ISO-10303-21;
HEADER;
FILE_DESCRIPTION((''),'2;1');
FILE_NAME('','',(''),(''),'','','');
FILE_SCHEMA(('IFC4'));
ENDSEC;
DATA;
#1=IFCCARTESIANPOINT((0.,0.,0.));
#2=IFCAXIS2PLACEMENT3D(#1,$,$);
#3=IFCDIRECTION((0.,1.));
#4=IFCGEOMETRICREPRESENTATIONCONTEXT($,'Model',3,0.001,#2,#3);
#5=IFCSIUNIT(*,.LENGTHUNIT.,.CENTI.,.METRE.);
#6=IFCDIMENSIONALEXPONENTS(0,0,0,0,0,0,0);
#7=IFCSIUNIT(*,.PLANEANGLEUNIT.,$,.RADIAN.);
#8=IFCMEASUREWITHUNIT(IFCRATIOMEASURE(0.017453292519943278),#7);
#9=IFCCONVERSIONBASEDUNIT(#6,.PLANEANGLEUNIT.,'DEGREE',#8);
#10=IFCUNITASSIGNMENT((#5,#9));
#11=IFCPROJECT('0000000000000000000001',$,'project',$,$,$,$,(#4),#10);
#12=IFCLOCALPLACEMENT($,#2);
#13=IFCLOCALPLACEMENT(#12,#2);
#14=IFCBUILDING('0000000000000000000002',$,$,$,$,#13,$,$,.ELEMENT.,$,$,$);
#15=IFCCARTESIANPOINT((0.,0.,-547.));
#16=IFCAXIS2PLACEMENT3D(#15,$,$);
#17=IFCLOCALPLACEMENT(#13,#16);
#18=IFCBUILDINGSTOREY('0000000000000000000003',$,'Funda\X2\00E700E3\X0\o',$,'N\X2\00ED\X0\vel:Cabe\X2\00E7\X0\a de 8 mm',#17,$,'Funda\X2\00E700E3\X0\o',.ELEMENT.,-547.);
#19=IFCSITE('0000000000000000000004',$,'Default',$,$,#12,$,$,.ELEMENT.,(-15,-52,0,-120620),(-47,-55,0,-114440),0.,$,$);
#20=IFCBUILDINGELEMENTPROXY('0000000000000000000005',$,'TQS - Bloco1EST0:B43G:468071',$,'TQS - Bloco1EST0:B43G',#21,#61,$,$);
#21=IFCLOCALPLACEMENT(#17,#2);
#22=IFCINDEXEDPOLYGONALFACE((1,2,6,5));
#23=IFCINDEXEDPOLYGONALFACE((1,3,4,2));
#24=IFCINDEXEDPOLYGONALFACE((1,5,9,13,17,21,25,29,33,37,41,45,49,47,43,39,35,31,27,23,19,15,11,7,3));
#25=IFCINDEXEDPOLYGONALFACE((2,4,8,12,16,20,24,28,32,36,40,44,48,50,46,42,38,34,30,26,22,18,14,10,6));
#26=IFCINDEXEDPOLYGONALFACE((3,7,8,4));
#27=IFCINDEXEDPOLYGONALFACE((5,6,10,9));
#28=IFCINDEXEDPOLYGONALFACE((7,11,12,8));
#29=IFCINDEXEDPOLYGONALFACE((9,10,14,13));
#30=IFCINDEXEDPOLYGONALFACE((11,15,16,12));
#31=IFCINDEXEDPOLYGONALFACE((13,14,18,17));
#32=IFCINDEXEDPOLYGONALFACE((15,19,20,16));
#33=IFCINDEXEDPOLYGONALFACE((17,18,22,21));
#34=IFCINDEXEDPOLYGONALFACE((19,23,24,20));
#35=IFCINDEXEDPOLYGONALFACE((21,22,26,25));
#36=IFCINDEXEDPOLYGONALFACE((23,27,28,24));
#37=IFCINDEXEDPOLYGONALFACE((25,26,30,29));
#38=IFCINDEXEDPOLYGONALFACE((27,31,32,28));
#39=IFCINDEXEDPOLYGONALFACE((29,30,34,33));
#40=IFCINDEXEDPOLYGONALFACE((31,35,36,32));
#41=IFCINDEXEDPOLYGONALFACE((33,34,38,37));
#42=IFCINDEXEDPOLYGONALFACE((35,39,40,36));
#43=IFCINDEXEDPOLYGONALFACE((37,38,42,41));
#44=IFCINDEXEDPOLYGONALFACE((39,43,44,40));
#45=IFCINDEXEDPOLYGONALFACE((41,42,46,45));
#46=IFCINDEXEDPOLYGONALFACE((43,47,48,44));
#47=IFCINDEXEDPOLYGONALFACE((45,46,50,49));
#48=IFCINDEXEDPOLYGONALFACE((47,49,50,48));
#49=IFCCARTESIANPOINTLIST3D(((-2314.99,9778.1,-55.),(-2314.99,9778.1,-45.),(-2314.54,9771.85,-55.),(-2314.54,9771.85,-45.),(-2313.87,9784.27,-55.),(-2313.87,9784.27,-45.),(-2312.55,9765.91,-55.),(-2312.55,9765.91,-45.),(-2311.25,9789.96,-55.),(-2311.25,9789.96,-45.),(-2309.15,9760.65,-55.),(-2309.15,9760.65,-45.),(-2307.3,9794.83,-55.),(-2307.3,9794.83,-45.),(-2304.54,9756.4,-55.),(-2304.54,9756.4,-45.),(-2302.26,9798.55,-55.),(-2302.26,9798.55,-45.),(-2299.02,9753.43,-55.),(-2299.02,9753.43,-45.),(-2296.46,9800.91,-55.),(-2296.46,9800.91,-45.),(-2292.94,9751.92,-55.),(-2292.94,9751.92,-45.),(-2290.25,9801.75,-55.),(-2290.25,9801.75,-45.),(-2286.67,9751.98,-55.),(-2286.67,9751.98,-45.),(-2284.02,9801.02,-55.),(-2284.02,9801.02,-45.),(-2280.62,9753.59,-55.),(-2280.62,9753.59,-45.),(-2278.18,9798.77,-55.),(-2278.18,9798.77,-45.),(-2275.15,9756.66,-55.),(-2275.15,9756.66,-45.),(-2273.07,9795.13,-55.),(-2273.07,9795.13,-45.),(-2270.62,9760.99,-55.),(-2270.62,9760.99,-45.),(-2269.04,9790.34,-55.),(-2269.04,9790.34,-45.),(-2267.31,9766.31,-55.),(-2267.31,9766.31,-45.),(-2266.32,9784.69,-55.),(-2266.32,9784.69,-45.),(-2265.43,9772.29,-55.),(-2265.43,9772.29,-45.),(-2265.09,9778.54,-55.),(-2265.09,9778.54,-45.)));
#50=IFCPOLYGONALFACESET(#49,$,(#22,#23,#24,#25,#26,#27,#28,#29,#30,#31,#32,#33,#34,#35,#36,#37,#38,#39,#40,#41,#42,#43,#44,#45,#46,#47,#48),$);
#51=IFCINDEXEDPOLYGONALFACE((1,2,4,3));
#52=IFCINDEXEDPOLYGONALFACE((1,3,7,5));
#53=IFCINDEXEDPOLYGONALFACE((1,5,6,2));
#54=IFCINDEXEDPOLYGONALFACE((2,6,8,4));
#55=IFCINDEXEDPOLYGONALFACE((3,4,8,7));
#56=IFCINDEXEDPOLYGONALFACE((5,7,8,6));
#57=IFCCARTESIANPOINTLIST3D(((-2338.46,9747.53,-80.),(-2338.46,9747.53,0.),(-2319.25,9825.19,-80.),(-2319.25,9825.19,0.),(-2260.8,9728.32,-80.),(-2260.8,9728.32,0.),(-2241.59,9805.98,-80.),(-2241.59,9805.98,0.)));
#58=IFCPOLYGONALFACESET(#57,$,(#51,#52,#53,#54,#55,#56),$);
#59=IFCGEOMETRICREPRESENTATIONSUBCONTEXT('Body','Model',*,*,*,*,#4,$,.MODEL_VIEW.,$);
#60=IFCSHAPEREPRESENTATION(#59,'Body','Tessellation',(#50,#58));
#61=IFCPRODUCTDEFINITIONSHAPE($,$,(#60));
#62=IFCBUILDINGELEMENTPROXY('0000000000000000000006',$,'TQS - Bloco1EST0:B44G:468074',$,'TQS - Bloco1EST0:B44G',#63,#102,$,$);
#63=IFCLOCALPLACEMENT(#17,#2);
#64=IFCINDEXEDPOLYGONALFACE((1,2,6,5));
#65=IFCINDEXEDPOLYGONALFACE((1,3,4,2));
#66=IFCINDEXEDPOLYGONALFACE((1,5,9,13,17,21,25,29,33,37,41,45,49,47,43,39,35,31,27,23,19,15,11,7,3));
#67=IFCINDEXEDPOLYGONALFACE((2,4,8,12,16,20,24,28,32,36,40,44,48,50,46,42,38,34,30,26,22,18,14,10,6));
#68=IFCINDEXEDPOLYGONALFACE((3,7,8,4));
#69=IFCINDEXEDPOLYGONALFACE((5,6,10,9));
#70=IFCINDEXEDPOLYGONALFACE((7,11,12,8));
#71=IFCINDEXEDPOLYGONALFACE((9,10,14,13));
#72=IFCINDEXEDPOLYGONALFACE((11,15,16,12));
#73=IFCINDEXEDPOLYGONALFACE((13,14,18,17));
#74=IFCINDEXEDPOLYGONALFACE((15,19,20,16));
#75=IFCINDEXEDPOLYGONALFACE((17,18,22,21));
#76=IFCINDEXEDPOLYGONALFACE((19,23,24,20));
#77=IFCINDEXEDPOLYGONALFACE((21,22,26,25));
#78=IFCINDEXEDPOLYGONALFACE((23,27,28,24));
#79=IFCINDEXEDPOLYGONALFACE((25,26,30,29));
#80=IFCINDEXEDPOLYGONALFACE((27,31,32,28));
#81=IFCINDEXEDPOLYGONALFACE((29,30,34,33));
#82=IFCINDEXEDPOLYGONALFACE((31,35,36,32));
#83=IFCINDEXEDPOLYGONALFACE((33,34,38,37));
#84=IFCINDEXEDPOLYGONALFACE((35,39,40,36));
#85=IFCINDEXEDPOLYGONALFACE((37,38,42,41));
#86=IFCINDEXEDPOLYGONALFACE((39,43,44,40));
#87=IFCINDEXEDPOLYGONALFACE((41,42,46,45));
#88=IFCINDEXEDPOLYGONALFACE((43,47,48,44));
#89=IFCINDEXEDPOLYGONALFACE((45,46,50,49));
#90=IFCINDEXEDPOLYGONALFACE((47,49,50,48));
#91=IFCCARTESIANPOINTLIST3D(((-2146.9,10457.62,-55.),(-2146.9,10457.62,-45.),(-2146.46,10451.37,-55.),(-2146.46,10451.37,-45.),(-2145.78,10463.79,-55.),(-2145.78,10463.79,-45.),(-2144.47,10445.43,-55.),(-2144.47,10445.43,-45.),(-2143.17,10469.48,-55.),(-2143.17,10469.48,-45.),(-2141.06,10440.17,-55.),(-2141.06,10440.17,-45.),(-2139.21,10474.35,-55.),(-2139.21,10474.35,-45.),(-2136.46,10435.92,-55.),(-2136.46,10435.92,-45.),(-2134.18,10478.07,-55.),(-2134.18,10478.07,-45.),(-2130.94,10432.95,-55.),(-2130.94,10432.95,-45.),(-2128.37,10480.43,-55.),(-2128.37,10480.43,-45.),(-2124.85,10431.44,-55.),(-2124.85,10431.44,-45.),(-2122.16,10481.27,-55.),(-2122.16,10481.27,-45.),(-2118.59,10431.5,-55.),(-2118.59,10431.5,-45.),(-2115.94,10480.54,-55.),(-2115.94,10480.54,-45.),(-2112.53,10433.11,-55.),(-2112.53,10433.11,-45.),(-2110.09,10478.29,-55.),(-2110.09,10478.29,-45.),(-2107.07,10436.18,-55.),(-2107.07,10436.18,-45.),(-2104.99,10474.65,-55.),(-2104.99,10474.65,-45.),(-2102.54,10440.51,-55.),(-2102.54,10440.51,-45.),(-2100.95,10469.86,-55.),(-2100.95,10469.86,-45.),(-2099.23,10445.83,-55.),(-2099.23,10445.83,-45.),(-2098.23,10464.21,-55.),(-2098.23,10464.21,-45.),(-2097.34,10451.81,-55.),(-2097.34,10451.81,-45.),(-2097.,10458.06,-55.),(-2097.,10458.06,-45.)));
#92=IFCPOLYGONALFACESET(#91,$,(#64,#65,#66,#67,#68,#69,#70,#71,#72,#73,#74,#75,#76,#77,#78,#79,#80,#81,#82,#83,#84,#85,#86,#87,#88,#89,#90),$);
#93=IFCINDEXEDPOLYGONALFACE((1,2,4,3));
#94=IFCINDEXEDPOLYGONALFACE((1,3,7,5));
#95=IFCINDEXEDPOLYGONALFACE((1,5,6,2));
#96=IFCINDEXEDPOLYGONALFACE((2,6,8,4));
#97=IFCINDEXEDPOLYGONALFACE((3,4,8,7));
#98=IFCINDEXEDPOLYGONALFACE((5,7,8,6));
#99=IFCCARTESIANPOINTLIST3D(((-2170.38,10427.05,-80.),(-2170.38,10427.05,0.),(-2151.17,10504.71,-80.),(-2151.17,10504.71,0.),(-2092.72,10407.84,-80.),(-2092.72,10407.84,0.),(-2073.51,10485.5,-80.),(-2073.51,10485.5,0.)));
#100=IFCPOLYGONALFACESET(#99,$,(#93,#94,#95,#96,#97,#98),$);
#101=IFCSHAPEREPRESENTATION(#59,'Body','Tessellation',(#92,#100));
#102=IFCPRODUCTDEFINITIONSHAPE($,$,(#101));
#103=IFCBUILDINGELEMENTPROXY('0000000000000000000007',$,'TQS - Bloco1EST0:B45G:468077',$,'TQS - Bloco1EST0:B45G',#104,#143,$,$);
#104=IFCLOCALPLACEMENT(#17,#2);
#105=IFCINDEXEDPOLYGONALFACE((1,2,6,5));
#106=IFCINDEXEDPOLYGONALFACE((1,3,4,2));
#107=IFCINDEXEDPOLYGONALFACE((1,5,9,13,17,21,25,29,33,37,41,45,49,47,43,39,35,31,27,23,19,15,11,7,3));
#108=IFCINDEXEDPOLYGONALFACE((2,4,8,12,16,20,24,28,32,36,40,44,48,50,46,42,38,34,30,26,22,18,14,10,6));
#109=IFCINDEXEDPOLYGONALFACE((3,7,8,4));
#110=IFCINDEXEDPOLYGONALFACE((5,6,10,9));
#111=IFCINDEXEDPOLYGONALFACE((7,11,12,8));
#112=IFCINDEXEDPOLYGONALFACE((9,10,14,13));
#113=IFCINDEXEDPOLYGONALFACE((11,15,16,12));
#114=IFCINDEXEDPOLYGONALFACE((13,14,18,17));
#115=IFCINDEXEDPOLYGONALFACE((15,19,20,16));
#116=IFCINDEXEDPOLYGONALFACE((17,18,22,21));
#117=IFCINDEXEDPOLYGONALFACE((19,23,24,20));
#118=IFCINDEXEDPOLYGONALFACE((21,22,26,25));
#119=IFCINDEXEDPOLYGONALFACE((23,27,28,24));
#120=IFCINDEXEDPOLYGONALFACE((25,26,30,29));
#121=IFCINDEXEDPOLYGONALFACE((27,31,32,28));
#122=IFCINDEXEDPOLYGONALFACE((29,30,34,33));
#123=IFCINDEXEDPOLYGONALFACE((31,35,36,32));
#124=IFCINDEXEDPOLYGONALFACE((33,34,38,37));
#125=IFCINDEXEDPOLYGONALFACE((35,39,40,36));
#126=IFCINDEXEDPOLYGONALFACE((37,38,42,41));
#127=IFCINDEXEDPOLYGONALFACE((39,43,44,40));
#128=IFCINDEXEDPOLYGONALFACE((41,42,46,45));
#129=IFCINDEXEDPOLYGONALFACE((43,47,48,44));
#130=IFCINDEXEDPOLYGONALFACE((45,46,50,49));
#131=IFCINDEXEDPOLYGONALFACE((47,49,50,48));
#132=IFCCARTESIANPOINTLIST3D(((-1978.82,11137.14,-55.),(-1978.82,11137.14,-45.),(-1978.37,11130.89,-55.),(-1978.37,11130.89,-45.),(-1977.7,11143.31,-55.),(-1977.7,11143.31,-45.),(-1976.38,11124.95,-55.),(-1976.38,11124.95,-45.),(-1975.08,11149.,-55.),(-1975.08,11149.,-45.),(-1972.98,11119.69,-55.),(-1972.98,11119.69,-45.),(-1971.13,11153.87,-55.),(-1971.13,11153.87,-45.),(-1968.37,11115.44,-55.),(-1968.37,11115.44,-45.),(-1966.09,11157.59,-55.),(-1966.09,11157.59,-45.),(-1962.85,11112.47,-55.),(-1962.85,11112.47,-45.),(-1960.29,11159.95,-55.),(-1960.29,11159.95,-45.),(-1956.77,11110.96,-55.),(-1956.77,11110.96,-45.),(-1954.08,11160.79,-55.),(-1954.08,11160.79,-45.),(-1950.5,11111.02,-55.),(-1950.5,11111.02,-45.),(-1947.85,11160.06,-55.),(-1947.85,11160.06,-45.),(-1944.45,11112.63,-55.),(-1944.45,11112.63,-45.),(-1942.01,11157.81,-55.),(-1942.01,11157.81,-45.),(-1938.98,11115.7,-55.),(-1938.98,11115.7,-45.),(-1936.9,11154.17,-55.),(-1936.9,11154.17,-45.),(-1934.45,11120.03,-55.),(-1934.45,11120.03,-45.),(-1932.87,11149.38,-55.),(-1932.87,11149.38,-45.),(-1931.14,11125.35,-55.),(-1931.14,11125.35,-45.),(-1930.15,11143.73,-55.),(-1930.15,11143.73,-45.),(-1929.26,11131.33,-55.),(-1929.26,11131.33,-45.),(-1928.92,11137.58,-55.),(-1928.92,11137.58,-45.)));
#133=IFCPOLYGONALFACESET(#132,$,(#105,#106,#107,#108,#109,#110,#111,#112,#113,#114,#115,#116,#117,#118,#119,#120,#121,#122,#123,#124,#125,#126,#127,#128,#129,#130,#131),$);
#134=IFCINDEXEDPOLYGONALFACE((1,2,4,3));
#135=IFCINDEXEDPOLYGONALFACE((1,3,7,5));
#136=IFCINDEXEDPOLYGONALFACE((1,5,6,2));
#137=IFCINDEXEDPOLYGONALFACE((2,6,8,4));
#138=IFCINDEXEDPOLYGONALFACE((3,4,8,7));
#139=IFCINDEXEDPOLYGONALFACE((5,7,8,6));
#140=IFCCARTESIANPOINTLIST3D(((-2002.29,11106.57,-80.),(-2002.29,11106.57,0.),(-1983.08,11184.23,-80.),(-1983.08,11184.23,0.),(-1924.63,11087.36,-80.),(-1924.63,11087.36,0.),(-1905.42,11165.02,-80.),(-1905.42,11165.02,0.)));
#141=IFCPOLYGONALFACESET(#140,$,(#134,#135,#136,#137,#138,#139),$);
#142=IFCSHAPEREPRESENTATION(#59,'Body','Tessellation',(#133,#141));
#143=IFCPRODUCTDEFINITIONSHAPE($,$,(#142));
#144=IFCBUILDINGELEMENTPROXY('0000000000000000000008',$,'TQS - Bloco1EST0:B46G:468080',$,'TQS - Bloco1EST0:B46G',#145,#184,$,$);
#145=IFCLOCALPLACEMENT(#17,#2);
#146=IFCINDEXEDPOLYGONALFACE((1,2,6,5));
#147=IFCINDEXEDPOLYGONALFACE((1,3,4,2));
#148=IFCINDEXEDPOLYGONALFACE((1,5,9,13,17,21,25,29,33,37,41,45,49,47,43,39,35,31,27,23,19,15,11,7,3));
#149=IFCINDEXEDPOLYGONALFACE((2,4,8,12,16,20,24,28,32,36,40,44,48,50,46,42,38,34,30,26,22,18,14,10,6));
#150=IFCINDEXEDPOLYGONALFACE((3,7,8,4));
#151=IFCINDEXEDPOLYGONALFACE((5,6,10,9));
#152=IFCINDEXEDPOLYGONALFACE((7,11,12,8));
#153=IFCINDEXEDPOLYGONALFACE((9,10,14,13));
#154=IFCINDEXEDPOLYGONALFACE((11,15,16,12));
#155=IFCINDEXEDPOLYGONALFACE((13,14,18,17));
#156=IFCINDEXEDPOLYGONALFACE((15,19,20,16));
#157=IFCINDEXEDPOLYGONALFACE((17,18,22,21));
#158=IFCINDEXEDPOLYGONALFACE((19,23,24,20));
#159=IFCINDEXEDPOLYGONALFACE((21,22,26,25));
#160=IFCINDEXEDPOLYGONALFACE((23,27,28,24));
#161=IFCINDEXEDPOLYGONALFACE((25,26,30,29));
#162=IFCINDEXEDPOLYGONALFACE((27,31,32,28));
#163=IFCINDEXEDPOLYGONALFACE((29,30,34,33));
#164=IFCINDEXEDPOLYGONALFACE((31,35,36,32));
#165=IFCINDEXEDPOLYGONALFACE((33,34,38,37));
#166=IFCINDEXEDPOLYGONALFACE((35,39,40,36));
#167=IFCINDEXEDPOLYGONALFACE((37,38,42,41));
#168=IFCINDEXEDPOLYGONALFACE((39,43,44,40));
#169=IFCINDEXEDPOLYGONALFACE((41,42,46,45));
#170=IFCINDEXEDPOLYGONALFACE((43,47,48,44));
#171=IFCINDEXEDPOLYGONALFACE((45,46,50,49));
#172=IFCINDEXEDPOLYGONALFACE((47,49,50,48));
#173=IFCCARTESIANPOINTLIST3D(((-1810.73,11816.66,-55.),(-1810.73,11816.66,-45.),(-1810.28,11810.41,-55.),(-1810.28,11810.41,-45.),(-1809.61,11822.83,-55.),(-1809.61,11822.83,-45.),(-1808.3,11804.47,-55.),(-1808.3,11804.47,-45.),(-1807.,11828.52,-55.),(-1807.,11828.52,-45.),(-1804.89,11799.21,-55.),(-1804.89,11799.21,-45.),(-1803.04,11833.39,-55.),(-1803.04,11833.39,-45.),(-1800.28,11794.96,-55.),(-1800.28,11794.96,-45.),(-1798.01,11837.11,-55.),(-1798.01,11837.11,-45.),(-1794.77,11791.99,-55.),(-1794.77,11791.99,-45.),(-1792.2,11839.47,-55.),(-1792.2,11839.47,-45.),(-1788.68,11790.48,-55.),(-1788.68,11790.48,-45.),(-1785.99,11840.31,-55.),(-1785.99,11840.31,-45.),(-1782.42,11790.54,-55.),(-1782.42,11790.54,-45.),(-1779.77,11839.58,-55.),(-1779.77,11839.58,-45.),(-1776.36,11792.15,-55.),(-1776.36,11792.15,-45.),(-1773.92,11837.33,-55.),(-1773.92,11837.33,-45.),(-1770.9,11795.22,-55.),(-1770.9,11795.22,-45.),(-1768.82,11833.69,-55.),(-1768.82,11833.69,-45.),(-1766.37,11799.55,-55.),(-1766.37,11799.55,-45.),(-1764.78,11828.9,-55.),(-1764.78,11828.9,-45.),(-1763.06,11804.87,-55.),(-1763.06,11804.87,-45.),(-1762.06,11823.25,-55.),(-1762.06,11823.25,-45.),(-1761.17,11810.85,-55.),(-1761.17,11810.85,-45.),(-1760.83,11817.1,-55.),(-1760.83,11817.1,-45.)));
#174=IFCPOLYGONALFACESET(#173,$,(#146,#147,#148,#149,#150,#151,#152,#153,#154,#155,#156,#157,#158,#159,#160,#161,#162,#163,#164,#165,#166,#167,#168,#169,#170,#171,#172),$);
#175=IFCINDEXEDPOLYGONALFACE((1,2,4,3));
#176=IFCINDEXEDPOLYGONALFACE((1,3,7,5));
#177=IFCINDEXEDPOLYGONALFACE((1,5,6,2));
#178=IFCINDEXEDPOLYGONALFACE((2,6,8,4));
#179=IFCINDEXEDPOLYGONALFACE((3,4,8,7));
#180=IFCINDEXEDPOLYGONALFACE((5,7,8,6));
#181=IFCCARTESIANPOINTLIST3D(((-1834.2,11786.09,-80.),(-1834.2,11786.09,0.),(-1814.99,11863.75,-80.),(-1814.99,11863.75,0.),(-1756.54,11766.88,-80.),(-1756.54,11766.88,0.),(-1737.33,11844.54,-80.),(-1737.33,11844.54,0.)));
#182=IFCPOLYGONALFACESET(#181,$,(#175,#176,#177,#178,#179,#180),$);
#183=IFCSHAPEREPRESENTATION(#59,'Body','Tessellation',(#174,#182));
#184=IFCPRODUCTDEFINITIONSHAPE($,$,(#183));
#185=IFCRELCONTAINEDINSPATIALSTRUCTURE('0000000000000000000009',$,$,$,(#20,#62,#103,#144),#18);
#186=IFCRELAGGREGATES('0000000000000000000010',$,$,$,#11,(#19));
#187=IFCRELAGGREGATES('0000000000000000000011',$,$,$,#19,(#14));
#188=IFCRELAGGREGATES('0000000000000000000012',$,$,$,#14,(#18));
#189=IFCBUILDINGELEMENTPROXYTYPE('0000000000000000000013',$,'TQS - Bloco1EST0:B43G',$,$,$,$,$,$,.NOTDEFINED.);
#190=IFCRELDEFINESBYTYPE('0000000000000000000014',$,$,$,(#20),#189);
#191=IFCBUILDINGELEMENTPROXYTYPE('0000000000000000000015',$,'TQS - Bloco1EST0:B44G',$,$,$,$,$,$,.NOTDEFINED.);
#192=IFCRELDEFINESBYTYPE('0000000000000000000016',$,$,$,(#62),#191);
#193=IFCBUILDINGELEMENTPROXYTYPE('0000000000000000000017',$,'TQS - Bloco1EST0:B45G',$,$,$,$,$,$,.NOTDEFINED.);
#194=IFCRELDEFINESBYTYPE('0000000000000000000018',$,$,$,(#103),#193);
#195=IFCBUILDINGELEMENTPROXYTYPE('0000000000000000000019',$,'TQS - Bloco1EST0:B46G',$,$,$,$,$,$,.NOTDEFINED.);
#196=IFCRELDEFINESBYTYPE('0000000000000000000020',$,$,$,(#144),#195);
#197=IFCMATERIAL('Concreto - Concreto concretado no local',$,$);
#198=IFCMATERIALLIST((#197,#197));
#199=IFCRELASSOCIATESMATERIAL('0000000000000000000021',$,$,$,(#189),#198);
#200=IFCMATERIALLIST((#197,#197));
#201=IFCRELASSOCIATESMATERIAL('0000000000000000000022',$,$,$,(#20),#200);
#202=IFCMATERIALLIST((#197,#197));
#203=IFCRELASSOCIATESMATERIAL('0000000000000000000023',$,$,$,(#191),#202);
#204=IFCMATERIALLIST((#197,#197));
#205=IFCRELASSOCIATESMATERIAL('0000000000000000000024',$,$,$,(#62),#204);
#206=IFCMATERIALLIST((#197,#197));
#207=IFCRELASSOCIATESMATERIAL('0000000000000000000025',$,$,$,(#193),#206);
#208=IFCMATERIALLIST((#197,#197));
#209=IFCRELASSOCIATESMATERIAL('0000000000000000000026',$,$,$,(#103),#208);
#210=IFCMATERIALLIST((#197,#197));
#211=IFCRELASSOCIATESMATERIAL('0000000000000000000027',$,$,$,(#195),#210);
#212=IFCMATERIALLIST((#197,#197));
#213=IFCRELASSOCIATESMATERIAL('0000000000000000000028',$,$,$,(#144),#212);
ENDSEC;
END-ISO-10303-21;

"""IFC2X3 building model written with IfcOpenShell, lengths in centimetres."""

from ifc_helpers import new_model, entity, si_unit, converted_unit, direction, frame, frame_2d, origin, origin_2d_with_axis, place, context, subcontext, project, spatial, rectangle, circle, extrude, source, transform, mapped, material, material_list, type_object, type_shapes, element, save


model = new_model("IFC2X3")

# Units and contexts
model_context = context("Model", 3, precision=0.001, world=origin(), true_north=direction((0.0, 1.0)))
body_context = subcontext(model_context, "Body", "Model", "MODEL_VIEW")
ifc_project = project(units=[si_unit("LENGTHUNIT", "METRE", prefix="CENTI"), converted_unit("PLANEANGLEUNIT", "DEGREE", entity("IfcRatioMeasure", 0.017453292519943278), si_unit("PLANEANGLEUNIT", "RADIAN"), dimensions=[0, 0, 0, 0, 0, 0, 0])], contexts=[model_context])

# Site, building, storey
site_placement = place(None, origin())
site = spatial("IfcSite", under=ifc_project, at=site_placement, Name="Default", CompositionType="ELEMENT", RefLatitude=(-15, -52, 0, -120620), RefLongitude=(-47, -55, 0, -114440), RefElevation=0.0)
building_placement = place(site_placement, origin())
building = spatial("IfcBuilding", under=site, at=building_placement, CompositionType="ELEMENT")
storey_placement = place(building_placement, frame((0.0, 0.0, -547.0)))
storey = spatial("IfcBuildingStorey", under=building, at=storey_placement, Name="Fundação", ObjectType="Nível:Cabeça de 8 mm", LongName="Fundação", CompositionType="ELEMENT", Elevation=-547.0)

# Building element proxies
ifc_material_1 = material(Name="Concreto - Concreto concretado no local")
ifc_material_list_1 = material_list([ifc_material_1, ifc_material_1])
ifc_material_list_2 = material_list([ifc_material_1, ifc_material_1])
building_element_proxy_type_1 = type_object("IfcBuildingElementProxyType", Name="TQS - Bloco1EST0:B43G", PredefinedType="NOTDEFINED", material=ifc_material_list_2)
shared_shape_1 = source(origin(), body_context, "Body", "SweptSolid", [
    extrude(circle(Radius=25.0, at=frame_2d((0.0, 0.0), x_axis=(1.0, 0.0))), frame((0.0, 0.0, -55.0)), (0.0, 0.0, 1.0), 10.0),
    extrude(rectangle(XDim=80.0, YDim=80.0, at=origin_2d_with_axis()), frame((0.0, 0.0, -80.0), z_axis=(0.0, 0.0, 1.0), x_axis=(-1.0, 0.0, 0.0)), (0.0, 0.0, 1.0), 80.0),
])
type_shapes(building_element_proxy_type_1, [shared_shape_1])
proxy_1_placement = place(storey_placement, frame((-2290.03, 9776.75, 0.0), z_axis=(0.0, 0.0, 1.0), x_axis=(0.240122, 0.970743, 0.0)))
element("IfcBuildingElementProxy", 1, at=proxy_1_placement, inside=storey, type_object=building_element_proxy_type_1, material=ifc_material_list_1, Name="TQS - Bloco1EST0:B43G:468071", ObjectType="TQS - Bloco1EST0:B43G", context=body_context, shape_type="MappedRepresentation", body=[
    mapped(shared_shape_1, transform((0.0, 0.0, 0.0), scale=1.0)),
])
ifc_material_list_3 = material_list([ifc_material_1, ifc_material_1])
ifc_material_list_4 = material_list([ifc_material_1, ifc_material_1])
building_element_proxy_type_2 = type_object("IfcBuildingElementProxyType", Name="TQS - Bloco1EST0:B44G", PredefinedType="NOTDEFINED", material=ifc_material_list_4)
shared_shape_2 = source(origin(), body_context, "Body", "SweptSolid", [
    extrude(circle(Radius=25.0, at=frame_2d((0.0, 0.0), x_axis=(1.0, 0.0))), frame((0.0, 0.0, -55.0)), (0.0, 0.0, 1.0), 10.0),
    extrude(rectangle(XDim=80.0, YDim=80.0, at=origin_2d_with_axis()), frame((0.0, 0.0, -80.0), z_axis=(0.0, 0.0, 1.0), x_axis=(-1.0, 0.0, 0.0)), (0.0, 0.0, 1.0), 80.0),
])
type_shapes(building_element_proxy_type_2, [shared_shape_2])
proxy_2_placement = place(storey_placement, frame((-2121.94, 10456.27, 0.0), z_axis=(0.0, 0.0, 1.0), x_axis=(0.240122, 0.970743, 0.0)))
element("IfcBuildingElementProxy", 2, at=proxy_2_placement, inside=storey, type_object=building_element_proxy_type_2, material=ifc_material_list_3, Name="TQS - Bloco1EST0:B44G:468074", ObjectType="TQS - Bloco1EST0:B44G", context=body_context, shape_type="MappedRepresentation", body=[
    mapped(shared_shape_2, transform((0.0, 0.0, 0.0), scale=1.0)),
])
ifc_material_list_5 = material_list([ifc_material_1, ifc_material_1])
ifc_material_list_6 = material_list([ifc_material_1, ifc_material_1])
building_element_proxy_type_3 = type_object("IfcBuildingElementProxyType", Name="TQS - Bloco1EST0:B45G", PredefinedType="NOTDEFINED", material=ifc_material_list_6)
shared_shape_3 = source(origin(), body_context, "Body", "SweptSolid", [
    extrude(circle(Radius=25.0, at=frame_2d((0.0, 0.0), x_axis=(1.0, 0.0))), frame((0.0, 0.0, -55.0)), (0.0, 0.0, 1.0), 10.0),
    extrude(rectangle(XDim=80.0, YDim=80.0, at=origin_2d_with_axis()), frame((0.0, 0.0, -80.0), z_axis=(0.0, 0.0, 1.0), x_axis=(-1.0, 0.0, 0.0)), (0.0, 0.0, 1.0), 80.0),
])
type_shapes(building_element_proxy_type_3, [shared_shape_3])
proxy_3_placement = place(storey_placement, frame((-1953.86, 11135.79, 0.0), z_axis=(0.0, 0.0, 1.0), x_axis=(0.240122, 0.970743, 0.0)))
element("IfcBuildingElementProxy", 3, at=proxy_3_placement, inside=storey, type_object=building_element_proxy_type_3, material=ifc_material_list_5, Name="TQS - Bloco1EST0:B45G:468077", ObjectType="TQS - Bloco1EST0:B45G", context=body_context, shape_type="MappedRepresentation", body=[
    mapped(shared_shape_3, transform((0.0, 0.0, 0.0), scale=1.0)),
])
ifc_material_list_7 = material_list([ifc_material_1, ifc_material_1])
ifc_material_list_8 = material_list([ifc_material_1, ifc_material_1])
building_element_proxy_type_4 = type_object("IfcBuildingElementProxyType", Name="TQS - Bloco1EST0:B46G", PredefinedType="NOTDEFINED", material=ifc_material_list_8)
shared_shape_4 = source(origin(), body_context, "Body", "SweptSolid", [
    extrude(circle(Radius=25.0, at=frame_2d((0.0, 0.0), x_axis=(1.0, 0.0))), frame((0.0, 0.0, -55.0)), (0.0, 0.0, 1.0), 10.0),
    extrude(rectangle(XDim=80.0, YDim=80.0, at=origin_2d_with_axis()), frame((0.0, 0.0, -80.0), z_axis=(0.0, 0.0, 1.0), x_axis=(-1.0, 0.0, 0.0)), (0.0, 0.0, 1.0), 80.0),
])
type_shapes(building_element_proxy_type_4, [shared_shape_4])
proxy_4_placement = place(storey_placement, frame((-1785.77, 11815.31, 0.0), z_axis=(0.0, 0.0, 1.0), x_axis=(0.240122, 0.970743, 0.0)))
element("IfcBuildingElementProxy", 4, at=proxy_4_placement, inside=storey, type_object=building_element_proxy_type_4, material=ifc_material_list_7, Name="TQS - Bloco1EST0:B46G:468080", ObjectType="TQS - Bloco1EST0:B46G", context=body_context, shape_type="MappedRepresentation", body=[
    mapped(shared_shape_4, transform((0.0, 0.0, 0.0), scale=1.0)),
])

save(model, "model.ifc")
